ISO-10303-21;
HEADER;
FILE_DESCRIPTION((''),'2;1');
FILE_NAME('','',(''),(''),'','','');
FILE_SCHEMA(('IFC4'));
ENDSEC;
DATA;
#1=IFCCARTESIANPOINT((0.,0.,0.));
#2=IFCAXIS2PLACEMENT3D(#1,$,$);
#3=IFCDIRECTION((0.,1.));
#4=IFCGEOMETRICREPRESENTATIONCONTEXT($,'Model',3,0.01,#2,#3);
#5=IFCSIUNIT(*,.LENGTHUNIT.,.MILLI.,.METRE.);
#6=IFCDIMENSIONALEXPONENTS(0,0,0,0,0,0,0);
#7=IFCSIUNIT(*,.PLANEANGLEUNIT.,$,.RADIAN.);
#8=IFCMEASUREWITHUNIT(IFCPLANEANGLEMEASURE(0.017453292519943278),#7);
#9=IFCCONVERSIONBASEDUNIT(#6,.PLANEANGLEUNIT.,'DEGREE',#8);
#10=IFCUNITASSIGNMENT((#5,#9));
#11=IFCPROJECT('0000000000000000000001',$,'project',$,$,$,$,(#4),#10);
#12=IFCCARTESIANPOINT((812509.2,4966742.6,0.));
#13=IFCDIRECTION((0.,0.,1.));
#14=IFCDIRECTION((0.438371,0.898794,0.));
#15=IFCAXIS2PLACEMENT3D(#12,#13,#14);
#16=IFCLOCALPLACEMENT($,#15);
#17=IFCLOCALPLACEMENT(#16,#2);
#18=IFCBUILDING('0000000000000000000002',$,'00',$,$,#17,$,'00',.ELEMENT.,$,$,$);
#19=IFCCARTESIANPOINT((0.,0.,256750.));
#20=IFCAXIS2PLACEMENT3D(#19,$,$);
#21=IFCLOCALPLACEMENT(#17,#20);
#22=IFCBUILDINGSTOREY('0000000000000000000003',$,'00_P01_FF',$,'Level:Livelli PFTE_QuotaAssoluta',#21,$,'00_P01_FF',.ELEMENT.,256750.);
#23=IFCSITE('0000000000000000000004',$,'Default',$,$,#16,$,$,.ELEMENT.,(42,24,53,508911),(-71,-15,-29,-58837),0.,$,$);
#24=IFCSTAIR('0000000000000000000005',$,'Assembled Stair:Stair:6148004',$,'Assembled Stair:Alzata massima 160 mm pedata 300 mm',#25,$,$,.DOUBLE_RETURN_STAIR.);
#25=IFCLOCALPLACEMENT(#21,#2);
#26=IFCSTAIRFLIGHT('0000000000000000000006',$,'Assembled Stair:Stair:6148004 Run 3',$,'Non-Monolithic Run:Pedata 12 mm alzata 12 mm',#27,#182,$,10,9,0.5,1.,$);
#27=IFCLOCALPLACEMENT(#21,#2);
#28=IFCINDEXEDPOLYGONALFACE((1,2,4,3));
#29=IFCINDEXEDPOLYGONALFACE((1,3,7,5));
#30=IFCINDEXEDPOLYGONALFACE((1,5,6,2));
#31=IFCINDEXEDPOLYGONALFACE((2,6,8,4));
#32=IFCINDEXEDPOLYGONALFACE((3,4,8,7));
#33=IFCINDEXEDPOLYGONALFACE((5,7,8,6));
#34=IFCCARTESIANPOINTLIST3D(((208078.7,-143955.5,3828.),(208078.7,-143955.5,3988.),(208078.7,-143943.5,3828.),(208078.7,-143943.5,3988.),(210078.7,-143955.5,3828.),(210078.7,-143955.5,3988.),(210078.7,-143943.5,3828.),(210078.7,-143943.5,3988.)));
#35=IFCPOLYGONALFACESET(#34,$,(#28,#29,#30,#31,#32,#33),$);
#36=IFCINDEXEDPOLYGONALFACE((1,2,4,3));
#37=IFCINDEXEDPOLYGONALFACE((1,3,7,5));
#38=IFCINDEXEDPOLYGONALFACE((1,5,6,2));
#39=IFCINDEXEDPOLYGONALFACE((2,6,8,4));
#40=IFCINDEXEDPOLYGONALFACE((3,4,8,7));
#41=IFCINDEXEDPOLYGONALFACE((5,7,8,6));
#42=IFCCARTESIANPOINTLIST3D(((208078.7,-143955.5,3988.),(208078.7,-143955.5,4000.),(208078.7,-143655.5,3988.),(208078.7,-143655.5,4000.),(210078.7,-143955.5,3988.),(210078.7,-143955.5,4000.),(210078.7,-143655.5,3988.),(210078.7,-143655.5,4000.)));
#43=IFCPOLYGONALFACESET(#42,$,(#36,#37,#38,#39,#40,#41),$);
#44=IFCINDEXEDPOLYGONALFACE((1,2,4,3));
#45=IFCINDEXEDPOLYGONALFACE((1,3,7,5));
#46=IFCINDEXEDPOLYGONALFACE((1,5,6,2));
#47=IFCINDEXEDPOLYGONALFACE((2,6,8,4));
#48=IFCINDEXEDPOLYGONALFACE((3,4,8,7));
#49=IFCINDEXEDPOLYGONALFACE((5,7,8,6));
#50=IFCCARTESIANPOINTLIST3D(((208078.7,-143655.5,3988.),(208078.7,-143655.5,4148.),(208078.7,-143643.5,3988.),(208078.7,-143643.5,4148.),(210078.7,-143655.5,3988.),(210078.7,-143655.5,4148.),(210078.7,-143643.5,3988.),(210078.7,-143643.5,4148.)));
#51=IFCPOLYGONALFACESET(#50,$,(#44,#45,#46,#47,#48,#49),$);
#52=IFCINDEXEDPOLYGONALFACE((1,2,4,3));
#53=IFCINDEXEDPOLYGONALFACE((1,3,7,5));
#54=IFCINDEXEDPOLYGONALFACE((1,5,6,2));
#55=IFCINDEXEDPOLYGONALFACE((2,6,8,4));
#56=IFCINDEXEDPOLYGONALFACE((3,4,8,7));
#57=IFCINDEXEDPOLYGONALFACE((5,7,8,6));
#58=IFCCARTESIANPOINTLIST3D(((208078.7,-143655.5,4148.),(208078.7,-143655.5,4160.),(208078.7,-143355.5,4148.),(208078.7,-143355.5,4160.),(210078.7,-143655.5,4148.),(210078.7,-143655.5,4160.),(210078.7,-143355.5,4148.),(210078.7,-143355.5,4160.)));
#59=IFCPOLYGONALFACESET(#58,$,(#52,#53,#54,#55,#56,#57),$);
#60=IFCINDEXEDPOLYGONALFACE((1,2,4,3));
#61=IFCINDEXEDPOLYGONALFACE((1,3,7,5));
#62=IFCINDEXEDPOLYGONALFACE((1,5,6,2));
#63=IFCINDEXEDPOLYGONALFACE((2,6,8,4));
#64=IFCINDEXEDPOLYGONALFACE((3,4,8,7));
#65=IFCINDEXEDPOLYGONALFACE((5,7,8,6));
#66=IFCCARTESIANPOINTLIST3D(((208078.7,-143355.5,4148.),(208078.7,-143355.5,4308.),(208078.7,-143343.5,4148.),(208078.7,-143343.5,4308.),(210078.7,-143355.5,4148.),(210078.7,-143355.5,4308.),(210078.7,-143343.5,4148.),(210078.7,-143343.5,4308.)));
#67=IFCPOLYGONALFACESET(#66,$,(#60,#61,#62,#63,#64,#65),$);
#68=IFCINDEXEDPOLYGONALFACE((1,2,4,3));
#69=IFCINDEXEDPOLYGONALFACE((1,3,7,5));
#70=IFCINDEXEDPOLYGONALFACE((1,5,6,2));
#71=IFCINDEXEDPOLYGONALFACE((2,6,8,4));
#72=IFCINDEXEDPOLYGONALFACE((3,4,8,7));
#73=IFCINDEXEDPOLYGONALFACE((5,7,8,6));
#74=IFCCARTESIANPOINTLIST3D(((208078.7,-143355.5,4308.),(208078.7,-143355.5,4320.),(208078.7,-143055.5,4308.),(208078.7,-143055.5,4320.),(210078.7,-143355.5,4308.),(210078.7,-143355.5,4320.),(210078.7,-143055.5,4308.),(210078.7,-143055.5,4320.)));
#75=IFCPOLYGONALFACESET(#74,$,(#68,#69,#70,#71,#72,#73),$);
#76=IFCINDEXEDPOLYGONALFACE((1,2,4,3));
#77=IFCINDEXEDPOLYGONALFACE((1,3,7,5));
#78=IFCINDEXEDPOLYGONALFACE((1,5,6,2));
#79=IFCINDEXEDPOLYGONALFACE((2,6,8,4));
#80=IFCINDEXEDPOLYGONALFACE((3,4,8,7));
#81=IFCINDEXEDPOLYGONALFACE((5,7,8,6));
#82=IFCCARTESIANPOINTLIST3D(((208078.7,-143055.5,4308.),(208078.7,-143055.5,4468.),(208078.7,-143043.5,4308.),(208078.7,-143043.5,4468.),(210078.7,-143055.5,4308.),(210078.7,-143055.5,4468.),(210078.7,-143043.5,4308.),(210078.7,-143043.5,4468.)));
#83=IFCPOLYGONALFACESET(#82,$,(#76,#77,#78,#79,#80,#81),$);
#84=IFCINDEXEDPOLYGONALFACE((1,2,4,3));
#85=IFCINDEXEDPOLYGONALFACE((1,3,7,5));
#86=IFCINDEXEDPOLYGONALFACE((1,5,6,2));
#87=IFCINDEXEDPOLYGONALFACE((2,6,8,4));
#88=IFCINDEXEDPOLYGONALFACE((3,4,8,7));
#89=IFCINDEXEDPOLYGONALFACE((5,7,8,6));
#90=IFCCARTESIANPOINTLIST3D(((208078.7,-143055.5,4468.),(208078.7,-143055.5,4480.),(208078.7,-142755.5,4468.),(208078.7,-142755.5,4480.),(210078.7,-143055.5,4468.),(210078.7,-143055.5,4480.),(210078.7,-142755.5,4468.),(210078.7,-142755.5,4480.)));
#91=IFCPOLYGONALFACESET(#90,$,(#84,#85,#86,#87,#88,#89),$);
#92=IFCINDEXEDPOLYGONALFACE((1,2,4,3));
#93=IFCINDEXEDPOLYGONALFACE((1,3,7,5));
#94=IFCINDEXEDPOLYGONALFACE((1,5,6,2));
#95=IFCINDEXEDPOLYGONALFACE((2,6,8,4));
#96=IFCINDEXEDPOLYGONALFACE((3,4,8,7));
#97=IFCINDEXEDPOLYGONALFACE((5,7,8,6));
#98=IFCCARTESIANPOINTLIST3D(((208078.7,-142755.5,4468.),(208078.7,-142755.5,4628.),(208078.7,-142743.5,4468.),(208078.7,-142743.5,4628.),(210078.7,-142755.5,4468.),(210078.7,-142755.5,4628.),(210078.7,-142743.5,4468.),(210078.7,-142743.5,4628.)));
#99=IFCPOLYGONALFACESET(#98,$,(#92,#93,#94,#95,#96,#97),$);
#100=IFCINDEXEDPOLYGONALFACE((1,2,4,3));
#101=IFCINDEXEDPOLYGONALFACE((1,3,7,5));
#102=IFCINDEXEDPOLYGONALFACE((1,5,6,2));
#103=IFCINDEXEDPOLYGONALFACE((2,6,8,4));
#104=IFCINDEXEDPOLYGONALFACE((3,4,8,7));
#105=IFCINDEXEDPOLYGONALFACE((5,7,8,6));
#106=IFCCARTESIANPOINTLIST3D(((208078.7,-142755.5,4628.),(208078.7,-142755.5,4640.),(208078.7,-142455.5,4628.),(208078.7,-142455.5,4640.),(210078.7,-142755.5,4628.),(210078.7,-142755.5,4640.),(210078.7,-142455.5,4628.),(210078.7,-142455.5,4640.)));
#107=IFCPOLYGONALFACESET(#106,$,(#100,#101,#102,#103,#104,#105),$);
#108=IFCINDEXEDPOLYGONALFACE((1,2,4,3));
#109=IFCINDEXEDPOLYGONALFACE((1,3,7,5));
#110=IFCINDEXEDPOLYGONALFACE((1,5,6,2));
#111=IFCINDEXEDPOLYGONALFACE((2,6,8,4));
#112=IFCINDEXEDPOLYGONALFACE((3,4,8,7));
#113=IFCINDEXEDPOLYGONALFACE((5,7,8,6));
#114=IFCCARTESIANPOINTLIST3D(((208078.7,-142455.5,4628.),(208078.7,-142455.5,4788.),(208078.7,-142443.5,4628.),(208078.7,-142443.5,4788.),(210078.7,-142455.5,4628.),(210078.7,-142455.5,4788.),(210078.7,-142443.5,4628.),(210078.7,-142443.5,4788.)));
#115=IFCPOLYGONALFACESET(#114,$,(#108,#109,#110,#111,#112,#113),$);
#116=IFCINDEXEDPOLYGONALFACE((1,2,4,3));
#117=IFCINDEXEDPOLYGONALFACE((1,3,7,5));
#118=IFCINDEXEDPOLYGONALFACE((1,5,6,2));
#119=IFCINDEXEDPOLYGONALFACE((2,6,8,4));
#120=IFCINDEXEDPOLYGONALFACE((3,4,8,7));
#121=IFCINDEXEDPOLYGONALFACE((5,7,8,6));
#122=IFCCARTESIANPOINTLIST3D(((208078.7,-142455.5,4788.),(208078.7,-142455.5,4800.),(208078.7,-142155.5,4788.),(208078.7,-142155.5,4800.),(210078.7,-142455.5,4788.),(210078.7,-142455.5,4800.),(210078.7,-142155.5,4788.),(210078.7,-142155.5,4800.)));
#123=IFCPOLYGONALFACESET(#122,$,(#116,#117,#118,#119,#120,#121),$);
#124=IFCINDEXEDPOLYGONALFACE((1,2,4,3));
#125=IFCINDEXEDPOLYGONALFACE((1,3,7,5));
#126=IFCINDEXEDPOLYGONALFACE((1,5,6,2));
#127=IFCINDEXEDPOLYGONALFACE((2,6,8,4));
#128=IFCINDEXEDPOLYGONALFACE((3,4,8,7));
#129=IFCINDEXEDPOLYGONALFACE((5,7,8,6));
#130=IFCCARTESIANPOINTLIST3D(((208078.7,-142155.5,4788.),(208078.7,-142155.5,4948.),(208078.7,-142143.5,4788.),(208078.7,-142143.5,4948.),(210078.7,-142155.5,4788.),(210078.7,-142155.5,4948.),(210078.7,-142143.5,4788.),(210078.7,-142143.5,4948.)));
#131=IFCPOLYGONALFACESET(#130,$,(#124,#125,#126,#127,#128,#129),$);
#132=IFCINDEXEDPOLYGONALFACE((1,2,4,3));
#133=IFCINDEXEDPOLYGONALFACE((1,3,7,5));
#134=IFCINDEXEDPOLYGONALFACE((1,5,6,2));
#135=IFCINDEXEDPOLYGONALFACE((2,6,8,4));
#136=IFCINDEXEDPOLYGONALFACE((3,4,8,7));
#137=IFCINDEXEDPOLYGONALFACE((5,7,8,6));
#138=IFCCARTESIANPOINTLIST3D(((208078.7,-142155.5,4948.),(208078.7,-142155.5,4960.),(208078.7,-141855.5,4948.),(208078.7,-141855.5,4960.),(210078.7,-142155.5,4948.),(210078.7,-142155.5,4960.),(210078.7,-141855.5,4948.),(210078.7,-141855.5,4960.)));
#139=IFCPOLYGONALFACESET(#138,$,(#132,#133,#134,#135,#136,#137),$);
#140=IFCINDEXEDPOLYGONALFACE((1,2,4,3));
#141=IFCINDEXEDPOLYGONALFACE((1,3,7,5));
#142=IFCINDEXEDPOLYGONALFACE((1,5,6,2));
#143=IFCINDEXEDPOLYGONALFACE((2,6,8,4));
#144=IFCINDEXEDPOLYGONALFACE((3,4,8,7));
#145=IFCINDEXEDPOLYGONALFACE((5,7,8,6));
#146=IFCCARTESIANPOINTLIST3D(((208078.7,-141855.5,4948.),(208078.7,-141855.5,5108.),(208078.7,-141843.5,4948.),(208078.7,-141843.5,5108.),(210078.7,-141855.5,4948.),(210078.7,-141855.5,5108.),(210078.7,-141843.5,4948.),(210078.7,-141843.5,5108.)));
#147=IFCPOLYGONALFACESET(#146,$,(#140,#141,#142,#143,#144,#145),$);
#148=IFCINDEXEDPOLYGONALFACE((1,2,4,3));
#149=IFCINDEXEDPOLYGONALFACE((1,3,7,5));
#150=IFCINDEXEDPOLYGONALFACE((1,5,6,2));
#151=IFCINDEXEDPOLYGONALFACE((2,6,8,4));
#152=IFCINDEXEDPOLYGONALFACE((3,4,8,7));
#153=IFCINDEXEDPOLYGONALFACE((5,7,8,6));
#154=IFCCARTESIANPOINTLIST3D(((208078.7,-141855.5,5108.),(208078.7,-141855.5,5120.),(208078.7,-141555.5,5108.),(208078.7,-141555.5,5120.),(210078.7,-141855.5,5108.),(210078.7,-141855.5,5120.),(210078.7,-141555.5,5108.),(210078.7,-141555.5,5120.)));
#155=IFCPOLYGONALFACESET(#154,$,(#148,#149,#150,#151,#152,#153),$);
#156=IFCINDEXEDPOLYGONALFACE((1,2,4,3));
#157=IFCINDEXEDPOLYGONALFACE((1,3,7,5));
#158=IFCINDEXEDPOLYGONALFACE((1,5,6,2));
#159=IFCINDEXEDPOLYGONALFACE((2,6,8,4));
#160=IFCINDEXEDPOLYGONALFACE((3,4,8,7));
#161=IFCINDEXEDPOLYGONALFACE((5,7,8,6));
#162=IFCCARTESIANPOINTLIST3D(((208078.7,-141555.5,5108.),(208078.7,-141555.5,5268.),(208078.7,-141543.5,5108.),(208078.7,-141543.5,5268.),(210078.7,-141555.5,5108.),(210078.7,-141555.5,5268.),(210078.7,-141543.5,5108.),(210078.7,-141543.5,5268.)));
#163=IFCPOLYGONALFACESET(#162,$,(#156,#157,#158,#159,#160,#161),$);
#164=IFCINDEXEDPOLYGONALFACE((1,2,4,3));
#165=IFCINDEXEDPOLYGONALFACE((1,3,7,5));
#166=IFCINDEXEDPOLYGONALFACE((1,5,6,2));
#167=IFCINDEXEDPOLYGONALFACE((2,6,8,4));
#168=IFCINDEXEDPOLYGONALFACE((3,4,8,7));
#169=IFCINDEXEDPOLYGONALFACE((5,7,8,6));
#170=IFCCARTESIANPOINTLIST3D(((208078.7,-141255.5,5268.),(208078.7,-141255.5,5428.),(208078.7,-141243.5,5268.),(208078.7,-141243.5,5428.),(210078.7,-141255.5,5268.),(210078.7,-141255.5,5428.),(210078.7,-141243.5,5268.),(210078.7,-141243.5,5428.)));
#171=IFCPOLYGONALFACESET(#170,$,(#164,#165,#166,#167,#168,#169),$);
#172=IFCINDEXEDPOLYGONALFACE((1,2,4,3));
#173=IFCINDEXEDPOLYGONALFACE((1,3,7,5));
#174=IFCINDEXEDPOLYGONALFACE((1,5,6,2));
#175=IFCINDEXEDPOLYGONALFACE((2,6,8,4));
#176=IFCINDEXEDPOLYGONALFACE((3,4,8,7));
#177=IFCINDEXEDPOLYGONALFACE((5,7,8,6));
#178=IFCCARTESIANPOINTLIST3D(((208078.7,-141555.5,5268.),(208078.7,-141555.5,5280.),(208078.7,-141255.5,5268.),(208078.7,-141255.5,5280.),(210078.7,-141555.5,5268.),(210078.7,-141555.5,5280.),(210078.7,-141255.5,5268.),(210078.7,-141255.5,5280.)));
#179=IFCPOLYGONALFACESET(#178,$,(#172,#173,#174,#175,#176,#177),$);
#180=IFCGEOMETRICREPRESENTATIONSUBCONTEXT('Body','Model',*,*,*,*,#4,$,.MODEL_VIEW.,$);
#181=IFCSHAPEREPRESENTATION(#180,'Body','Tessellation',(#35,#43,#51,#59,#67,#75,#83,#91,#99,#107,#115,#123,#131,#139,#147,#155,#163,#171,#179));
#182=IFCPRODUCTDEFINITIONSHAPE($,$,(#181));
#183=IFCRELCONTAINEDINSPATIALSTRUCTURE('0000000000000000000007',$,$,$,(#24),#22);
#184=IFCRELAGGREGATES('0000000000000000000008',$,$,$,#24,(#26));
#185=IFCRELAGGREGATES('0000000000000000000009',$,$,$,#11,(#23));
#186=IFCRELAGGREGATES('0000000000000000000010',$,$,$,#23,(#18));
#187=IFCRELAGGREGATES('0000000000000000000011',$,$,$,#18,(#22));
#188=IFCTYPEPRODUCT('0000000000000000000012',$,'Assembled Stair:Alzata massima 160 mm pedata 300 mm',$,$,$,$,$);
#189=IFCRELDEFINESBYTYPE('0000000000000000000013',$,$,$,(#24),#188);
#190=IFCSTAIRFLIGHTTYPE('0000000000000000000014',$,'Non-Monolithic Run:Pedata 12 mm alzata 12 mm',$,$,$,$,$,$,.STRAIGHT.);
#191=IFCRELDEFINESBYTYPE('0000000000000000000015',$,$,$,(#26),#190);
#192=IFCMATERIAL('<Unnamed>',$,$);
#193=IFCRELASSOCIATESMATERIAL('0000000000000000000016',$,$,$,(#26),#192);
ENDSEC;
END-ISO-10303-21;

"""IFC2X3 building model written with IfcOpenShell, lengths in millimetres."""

from ifc_helpers import new_model, entity, si_unit, converted_unit, direction, frame, origin, origin_2d_with_axis, place, context, subcontext, project, spatial, rectangle, extrude, material, type_object, element, aggregate, save


model = new_model("IFC2X3")

# Units and contexts
model_context = context("Model", 3, precision=0.01, world=origin(), true_north=direction((0.0, 1.0)))
body_context = subcontext(model_context, "Body", "Model", "MODEL_VIEW")
ifc_project = project(units=[si_unit("LENGTHUNIT", "METRE", prefix="MILLI"), converted_unit("PLANEANGLEUNIT", "DEGREE", entity("IfcPlaneAngleMeasure", 0.017453292519943278), si_unit("PLANEANGLEUNIT", "RADIAN"), dimensions=[0, 0, 0, 0, 0, 0, 0])], contexts=[model_context])

# Site, building, storey
site_placement = place(None, frame((812509.2, 4966742.6, 0.0), z_axis=(0.0, 0.0, 1.0), x_axis=(0.438371, 0.898794, 0.0)))
site = spatial("IfcSite", under=ifc_project, at=site_placement, Name="Default", CompositionType="ELEMENT", RefLatitude=(42, 24, 53, 508911), RefLongitude=(-71, -15, -29, -58837), RefElevation=0.0)
building_placement = place(site_placement, origin())
building = spatial("IfcBuilding", under=site, at=building_placement, Name="00", LongName="00", CompositionType="ELEMENT")
storey_placement = place(building_placement, frame((0.0, 0.0, 256750.0)))
storey = spatial("IfcBuildingStorey", under=building, at=storey_placement, Name="00_P01_FF", ObjectType="Level:Livelli PFTE_QuotaAssoluta", LongName="00_P01_FF", CompositionType="ELEMENT", Elevation=256750.0)

# Stair
type_product = type_object("IfcTypeProduct", Name="Assembled Stair:Alzata massima 160 mm pedata 300 mm")
ifc_material = material(Name="<Unnamed>")
stair_1_placement = place(storey_placement, origin())
stair_1 = element("IfcStair", 1, at=stair_1_placement, inside=storey, type_object=type_product, Name="Assembled Stair:Stair:6148004", ObjectType="Assembled Stair:Alzata massima 160 mm pedata 300 mm", ShapeType="DOUBLE_RETURN_STAIR")

# Stair flight
stair_flight_type = type_object("IfcStairFlightType", Name="Non-Monolithic Run:Pedata 12 mm alzata 12 mm", PredefinedType="STRAIGHT")
stair_flight_1_placement = place(stair_1_placement, origin())
stair_flight_1 = element("IfcStairFlight", 2, at=stair_flight_1_placement, type_object=stair_flight_type, material=ifc_material, Name="Assembled Stair:Stair:6148004 Run 3", ObjectType="Non-Monolithic Run:Pedata 12 mm alzata 12 mm", NumberOfRiser=10, NumberOfTreads=9, RiserHeight=0.5, TreadLength=1.0, context=body_context, shape_type="SweptSolid", body=[
    extrude(rectangle(XDim=2000.0, YDim=12.0, at=origin_2d_with_axis()), frame((209078.7, -143949.5, 3828.0), z_axis=(0.0, 0.0, 1.0), x_axis=(-1.0, 0.0, 0.0)), (0.0, 0.0, 1.0), 160.0),
    extrude(rectangle(XDim=300.0, YDim=2000.0, at=origin_2d_with_axis()), frame((209078.7, -143805.5, 3988.0), z_axis=(0.0, 0.0, 1.0), x_axis=(0.0, -1.0, 0.0)), (0.0, 0.0, 1.0), 12.0),
    extrude(rectangle(XDim=2000.0, YDim=12.0, at=origin_2d_with_axis()), frame((209078.7, -143649.5, 3988.0), z_axis=(0.0, 0.0, 1.0), x_axis=(-1.0, 0.0, 0.0)), (0.0, 0.0, 1.0), 160.0),
    extrude(rectangle(XDim=300.0, YDim=2000.0, at=origin_2d_with_axis()), frame((209078.7, -143505.5, 4148.0), z_axis=(0.0, 0.0, 1.0), x_axis=(0.0, -1.0, 0.0)), (0.0, 0.0, 1.0), 12.0),
    extrude(rectangle(XDim=2000.0, YDim=12.0, at=origin_2d_with_axis()), frame((209078.7, -143349.5, 4148.0), z_axis=(0.0, 0.0, 1.0), x_axis=(-1.0, 0.0, 0.0)), (0.0, 0.0, 1.0), 160.0),
    extrude(rectangle(XDim=300.0, YDim=2000.0, at=origin_2d_with_axis()), frame((209078.7, -143205.5, 4308.0), z_axis=(0.0, 0.0, 1.0), x_axis=(0.0, -1.0, 0.0)), (0.0, 0.0, 1.0), 12.0),
    extrude(rectangle(XDim=2000.0, YDim=12.0, at=origin_2d_with_axis()), frame((209078.7, -143049.5, 4308.0), z_axis=(0.0, 0.0, 1.0), x_axis=(-1.0, 0.0, 0.0)), (0.0, 0.0, 1.0), 160.0),
    extrude(rectangle(XDim=300.0, YDim=2000.0, at=origin_2d_with_axis()), frame((209078.7, -142905.5, 4468.0), z_axis=(0.0, 0.0, 1.0), x_axis=(0.0, -1.0, 0.0)), (0.0, 0.0, 1.0), 12.0),
    extrude(rectangle(XDim=2000.0, YDim=12.0, at=origin_2d_with_axis()), frame((209078.7, -142749.5, 4468.0), z_axis=(0.0, 0.0, 1.0), x_axis=(-1.0, 0.0, 0.0)), (0.0, 0.0, 1.0), 160.0),
    extrude(rectangle(XDim=300.0, YDim=2000.0, at=origin_2d_with_axis()), frame((209078.7, -142605.5, 4628.0), z_axis=(0.0, 0.0, 1.0), x_axis=(0.0, -1.0, 0.0)), (0.0, 0.0, 1.0), 12.0),
    extrude(rectangle(XDim=2000.0, YDim=12.0, at=origin_2d_with_axis()), frame((209078.7, -142449.5, 4628.0), z_axis=(0.0, 0.0, 1.0), x_axis=(-1.0, 0.0, 0.0)), (0.0, 0.0, 1.0), 160.0),
    extrude(rectangle(XDim=300.0, YDim=2000.0, at=origin_2d_with_axis()), frame((209078.7, -142305.5, 4788.0), z_axis=(0.0, 0.0, 1.0), x_axis=(0.0, -1.0, 0.0)), (0.0, 0.0, 1.0), 12.0),
    extrude(rectangle(XDim=2000.0, YDim=12.0, at=origin_2d_with_axis()), frame((209078.7, -142149.5, 4788.0), z_axis=(0.0, 0.0, 1.0), x_axis=(-1.0, 0.0, 0.0)), (0.0, 0.0, 1.0), 160.0),
    extrude(rectangle(XDim=300.0, YDim=2000.0, at=origin_2d_with_axis()), frame((209078.7, -142005.5, 4948.0), z_axis=(0.0, 0.0, 1.0), x_axis=(0.0, -1.0, 0.0)), (0.0, 0.0, 1.0), 12.0),
    extrude(rectangle(XDim=2000.0, YDim=12.0, at=origin_2d_with_axis()), frame((209078.7, -141849.5, 4948.0), z_axis=(0.0, 0.0, 1.0), x_axis=(-1.0, 0.0, 0.0)), (0.0, 0.0, 1.0), 160.0),
    extrude(rectangle(XDim=300.0, YDim=2000.0, at=origin_2d_with_axis()), frame((209078.7, -141705.5, 5108.0), z_axis=(0.0, 0.0, 1.0), x_axis=(0.0, -1.0, 0.0)), (0.0, 0.0, 1.0), 12.0),
    extrude(rectangle(XDim=2000.0, YDim=12.0, at=origin_2d_with_axis()), frame((209078.7, -141549.5, 5108.0), z_axis=(0.0, 0.0, 1.0), x_axis=(-1.0, 0.0, 0.0)), (0.0, 0.0, 1.0), 160.0),
    extrude(rectangle(XDim=2000.0, YDim=12.0, at=origin_2d_with_axis()), frame((209078.7, -141249.5, 5268.0), z_axis=(0.0, 0.0, 1.0), x_axis=(-1.0, 0.0, 0.0)), (0.0, 0.0, 1.0), 160.0),
    extrude(rectangle(XDim=300.0, YDim=2000.0, at=origin_2d_with_axis()), frame((209078.7, -141405.5, 5268.0), z_axis=(0.0, 0.0, 1.0), x_axis=(0.0, -1.0, 0.0)), (0.0, 0.0, 1.0), 12.0),
])
aggregate(stair_1, [stair_flight_1])

save(model, "model.ifc")
